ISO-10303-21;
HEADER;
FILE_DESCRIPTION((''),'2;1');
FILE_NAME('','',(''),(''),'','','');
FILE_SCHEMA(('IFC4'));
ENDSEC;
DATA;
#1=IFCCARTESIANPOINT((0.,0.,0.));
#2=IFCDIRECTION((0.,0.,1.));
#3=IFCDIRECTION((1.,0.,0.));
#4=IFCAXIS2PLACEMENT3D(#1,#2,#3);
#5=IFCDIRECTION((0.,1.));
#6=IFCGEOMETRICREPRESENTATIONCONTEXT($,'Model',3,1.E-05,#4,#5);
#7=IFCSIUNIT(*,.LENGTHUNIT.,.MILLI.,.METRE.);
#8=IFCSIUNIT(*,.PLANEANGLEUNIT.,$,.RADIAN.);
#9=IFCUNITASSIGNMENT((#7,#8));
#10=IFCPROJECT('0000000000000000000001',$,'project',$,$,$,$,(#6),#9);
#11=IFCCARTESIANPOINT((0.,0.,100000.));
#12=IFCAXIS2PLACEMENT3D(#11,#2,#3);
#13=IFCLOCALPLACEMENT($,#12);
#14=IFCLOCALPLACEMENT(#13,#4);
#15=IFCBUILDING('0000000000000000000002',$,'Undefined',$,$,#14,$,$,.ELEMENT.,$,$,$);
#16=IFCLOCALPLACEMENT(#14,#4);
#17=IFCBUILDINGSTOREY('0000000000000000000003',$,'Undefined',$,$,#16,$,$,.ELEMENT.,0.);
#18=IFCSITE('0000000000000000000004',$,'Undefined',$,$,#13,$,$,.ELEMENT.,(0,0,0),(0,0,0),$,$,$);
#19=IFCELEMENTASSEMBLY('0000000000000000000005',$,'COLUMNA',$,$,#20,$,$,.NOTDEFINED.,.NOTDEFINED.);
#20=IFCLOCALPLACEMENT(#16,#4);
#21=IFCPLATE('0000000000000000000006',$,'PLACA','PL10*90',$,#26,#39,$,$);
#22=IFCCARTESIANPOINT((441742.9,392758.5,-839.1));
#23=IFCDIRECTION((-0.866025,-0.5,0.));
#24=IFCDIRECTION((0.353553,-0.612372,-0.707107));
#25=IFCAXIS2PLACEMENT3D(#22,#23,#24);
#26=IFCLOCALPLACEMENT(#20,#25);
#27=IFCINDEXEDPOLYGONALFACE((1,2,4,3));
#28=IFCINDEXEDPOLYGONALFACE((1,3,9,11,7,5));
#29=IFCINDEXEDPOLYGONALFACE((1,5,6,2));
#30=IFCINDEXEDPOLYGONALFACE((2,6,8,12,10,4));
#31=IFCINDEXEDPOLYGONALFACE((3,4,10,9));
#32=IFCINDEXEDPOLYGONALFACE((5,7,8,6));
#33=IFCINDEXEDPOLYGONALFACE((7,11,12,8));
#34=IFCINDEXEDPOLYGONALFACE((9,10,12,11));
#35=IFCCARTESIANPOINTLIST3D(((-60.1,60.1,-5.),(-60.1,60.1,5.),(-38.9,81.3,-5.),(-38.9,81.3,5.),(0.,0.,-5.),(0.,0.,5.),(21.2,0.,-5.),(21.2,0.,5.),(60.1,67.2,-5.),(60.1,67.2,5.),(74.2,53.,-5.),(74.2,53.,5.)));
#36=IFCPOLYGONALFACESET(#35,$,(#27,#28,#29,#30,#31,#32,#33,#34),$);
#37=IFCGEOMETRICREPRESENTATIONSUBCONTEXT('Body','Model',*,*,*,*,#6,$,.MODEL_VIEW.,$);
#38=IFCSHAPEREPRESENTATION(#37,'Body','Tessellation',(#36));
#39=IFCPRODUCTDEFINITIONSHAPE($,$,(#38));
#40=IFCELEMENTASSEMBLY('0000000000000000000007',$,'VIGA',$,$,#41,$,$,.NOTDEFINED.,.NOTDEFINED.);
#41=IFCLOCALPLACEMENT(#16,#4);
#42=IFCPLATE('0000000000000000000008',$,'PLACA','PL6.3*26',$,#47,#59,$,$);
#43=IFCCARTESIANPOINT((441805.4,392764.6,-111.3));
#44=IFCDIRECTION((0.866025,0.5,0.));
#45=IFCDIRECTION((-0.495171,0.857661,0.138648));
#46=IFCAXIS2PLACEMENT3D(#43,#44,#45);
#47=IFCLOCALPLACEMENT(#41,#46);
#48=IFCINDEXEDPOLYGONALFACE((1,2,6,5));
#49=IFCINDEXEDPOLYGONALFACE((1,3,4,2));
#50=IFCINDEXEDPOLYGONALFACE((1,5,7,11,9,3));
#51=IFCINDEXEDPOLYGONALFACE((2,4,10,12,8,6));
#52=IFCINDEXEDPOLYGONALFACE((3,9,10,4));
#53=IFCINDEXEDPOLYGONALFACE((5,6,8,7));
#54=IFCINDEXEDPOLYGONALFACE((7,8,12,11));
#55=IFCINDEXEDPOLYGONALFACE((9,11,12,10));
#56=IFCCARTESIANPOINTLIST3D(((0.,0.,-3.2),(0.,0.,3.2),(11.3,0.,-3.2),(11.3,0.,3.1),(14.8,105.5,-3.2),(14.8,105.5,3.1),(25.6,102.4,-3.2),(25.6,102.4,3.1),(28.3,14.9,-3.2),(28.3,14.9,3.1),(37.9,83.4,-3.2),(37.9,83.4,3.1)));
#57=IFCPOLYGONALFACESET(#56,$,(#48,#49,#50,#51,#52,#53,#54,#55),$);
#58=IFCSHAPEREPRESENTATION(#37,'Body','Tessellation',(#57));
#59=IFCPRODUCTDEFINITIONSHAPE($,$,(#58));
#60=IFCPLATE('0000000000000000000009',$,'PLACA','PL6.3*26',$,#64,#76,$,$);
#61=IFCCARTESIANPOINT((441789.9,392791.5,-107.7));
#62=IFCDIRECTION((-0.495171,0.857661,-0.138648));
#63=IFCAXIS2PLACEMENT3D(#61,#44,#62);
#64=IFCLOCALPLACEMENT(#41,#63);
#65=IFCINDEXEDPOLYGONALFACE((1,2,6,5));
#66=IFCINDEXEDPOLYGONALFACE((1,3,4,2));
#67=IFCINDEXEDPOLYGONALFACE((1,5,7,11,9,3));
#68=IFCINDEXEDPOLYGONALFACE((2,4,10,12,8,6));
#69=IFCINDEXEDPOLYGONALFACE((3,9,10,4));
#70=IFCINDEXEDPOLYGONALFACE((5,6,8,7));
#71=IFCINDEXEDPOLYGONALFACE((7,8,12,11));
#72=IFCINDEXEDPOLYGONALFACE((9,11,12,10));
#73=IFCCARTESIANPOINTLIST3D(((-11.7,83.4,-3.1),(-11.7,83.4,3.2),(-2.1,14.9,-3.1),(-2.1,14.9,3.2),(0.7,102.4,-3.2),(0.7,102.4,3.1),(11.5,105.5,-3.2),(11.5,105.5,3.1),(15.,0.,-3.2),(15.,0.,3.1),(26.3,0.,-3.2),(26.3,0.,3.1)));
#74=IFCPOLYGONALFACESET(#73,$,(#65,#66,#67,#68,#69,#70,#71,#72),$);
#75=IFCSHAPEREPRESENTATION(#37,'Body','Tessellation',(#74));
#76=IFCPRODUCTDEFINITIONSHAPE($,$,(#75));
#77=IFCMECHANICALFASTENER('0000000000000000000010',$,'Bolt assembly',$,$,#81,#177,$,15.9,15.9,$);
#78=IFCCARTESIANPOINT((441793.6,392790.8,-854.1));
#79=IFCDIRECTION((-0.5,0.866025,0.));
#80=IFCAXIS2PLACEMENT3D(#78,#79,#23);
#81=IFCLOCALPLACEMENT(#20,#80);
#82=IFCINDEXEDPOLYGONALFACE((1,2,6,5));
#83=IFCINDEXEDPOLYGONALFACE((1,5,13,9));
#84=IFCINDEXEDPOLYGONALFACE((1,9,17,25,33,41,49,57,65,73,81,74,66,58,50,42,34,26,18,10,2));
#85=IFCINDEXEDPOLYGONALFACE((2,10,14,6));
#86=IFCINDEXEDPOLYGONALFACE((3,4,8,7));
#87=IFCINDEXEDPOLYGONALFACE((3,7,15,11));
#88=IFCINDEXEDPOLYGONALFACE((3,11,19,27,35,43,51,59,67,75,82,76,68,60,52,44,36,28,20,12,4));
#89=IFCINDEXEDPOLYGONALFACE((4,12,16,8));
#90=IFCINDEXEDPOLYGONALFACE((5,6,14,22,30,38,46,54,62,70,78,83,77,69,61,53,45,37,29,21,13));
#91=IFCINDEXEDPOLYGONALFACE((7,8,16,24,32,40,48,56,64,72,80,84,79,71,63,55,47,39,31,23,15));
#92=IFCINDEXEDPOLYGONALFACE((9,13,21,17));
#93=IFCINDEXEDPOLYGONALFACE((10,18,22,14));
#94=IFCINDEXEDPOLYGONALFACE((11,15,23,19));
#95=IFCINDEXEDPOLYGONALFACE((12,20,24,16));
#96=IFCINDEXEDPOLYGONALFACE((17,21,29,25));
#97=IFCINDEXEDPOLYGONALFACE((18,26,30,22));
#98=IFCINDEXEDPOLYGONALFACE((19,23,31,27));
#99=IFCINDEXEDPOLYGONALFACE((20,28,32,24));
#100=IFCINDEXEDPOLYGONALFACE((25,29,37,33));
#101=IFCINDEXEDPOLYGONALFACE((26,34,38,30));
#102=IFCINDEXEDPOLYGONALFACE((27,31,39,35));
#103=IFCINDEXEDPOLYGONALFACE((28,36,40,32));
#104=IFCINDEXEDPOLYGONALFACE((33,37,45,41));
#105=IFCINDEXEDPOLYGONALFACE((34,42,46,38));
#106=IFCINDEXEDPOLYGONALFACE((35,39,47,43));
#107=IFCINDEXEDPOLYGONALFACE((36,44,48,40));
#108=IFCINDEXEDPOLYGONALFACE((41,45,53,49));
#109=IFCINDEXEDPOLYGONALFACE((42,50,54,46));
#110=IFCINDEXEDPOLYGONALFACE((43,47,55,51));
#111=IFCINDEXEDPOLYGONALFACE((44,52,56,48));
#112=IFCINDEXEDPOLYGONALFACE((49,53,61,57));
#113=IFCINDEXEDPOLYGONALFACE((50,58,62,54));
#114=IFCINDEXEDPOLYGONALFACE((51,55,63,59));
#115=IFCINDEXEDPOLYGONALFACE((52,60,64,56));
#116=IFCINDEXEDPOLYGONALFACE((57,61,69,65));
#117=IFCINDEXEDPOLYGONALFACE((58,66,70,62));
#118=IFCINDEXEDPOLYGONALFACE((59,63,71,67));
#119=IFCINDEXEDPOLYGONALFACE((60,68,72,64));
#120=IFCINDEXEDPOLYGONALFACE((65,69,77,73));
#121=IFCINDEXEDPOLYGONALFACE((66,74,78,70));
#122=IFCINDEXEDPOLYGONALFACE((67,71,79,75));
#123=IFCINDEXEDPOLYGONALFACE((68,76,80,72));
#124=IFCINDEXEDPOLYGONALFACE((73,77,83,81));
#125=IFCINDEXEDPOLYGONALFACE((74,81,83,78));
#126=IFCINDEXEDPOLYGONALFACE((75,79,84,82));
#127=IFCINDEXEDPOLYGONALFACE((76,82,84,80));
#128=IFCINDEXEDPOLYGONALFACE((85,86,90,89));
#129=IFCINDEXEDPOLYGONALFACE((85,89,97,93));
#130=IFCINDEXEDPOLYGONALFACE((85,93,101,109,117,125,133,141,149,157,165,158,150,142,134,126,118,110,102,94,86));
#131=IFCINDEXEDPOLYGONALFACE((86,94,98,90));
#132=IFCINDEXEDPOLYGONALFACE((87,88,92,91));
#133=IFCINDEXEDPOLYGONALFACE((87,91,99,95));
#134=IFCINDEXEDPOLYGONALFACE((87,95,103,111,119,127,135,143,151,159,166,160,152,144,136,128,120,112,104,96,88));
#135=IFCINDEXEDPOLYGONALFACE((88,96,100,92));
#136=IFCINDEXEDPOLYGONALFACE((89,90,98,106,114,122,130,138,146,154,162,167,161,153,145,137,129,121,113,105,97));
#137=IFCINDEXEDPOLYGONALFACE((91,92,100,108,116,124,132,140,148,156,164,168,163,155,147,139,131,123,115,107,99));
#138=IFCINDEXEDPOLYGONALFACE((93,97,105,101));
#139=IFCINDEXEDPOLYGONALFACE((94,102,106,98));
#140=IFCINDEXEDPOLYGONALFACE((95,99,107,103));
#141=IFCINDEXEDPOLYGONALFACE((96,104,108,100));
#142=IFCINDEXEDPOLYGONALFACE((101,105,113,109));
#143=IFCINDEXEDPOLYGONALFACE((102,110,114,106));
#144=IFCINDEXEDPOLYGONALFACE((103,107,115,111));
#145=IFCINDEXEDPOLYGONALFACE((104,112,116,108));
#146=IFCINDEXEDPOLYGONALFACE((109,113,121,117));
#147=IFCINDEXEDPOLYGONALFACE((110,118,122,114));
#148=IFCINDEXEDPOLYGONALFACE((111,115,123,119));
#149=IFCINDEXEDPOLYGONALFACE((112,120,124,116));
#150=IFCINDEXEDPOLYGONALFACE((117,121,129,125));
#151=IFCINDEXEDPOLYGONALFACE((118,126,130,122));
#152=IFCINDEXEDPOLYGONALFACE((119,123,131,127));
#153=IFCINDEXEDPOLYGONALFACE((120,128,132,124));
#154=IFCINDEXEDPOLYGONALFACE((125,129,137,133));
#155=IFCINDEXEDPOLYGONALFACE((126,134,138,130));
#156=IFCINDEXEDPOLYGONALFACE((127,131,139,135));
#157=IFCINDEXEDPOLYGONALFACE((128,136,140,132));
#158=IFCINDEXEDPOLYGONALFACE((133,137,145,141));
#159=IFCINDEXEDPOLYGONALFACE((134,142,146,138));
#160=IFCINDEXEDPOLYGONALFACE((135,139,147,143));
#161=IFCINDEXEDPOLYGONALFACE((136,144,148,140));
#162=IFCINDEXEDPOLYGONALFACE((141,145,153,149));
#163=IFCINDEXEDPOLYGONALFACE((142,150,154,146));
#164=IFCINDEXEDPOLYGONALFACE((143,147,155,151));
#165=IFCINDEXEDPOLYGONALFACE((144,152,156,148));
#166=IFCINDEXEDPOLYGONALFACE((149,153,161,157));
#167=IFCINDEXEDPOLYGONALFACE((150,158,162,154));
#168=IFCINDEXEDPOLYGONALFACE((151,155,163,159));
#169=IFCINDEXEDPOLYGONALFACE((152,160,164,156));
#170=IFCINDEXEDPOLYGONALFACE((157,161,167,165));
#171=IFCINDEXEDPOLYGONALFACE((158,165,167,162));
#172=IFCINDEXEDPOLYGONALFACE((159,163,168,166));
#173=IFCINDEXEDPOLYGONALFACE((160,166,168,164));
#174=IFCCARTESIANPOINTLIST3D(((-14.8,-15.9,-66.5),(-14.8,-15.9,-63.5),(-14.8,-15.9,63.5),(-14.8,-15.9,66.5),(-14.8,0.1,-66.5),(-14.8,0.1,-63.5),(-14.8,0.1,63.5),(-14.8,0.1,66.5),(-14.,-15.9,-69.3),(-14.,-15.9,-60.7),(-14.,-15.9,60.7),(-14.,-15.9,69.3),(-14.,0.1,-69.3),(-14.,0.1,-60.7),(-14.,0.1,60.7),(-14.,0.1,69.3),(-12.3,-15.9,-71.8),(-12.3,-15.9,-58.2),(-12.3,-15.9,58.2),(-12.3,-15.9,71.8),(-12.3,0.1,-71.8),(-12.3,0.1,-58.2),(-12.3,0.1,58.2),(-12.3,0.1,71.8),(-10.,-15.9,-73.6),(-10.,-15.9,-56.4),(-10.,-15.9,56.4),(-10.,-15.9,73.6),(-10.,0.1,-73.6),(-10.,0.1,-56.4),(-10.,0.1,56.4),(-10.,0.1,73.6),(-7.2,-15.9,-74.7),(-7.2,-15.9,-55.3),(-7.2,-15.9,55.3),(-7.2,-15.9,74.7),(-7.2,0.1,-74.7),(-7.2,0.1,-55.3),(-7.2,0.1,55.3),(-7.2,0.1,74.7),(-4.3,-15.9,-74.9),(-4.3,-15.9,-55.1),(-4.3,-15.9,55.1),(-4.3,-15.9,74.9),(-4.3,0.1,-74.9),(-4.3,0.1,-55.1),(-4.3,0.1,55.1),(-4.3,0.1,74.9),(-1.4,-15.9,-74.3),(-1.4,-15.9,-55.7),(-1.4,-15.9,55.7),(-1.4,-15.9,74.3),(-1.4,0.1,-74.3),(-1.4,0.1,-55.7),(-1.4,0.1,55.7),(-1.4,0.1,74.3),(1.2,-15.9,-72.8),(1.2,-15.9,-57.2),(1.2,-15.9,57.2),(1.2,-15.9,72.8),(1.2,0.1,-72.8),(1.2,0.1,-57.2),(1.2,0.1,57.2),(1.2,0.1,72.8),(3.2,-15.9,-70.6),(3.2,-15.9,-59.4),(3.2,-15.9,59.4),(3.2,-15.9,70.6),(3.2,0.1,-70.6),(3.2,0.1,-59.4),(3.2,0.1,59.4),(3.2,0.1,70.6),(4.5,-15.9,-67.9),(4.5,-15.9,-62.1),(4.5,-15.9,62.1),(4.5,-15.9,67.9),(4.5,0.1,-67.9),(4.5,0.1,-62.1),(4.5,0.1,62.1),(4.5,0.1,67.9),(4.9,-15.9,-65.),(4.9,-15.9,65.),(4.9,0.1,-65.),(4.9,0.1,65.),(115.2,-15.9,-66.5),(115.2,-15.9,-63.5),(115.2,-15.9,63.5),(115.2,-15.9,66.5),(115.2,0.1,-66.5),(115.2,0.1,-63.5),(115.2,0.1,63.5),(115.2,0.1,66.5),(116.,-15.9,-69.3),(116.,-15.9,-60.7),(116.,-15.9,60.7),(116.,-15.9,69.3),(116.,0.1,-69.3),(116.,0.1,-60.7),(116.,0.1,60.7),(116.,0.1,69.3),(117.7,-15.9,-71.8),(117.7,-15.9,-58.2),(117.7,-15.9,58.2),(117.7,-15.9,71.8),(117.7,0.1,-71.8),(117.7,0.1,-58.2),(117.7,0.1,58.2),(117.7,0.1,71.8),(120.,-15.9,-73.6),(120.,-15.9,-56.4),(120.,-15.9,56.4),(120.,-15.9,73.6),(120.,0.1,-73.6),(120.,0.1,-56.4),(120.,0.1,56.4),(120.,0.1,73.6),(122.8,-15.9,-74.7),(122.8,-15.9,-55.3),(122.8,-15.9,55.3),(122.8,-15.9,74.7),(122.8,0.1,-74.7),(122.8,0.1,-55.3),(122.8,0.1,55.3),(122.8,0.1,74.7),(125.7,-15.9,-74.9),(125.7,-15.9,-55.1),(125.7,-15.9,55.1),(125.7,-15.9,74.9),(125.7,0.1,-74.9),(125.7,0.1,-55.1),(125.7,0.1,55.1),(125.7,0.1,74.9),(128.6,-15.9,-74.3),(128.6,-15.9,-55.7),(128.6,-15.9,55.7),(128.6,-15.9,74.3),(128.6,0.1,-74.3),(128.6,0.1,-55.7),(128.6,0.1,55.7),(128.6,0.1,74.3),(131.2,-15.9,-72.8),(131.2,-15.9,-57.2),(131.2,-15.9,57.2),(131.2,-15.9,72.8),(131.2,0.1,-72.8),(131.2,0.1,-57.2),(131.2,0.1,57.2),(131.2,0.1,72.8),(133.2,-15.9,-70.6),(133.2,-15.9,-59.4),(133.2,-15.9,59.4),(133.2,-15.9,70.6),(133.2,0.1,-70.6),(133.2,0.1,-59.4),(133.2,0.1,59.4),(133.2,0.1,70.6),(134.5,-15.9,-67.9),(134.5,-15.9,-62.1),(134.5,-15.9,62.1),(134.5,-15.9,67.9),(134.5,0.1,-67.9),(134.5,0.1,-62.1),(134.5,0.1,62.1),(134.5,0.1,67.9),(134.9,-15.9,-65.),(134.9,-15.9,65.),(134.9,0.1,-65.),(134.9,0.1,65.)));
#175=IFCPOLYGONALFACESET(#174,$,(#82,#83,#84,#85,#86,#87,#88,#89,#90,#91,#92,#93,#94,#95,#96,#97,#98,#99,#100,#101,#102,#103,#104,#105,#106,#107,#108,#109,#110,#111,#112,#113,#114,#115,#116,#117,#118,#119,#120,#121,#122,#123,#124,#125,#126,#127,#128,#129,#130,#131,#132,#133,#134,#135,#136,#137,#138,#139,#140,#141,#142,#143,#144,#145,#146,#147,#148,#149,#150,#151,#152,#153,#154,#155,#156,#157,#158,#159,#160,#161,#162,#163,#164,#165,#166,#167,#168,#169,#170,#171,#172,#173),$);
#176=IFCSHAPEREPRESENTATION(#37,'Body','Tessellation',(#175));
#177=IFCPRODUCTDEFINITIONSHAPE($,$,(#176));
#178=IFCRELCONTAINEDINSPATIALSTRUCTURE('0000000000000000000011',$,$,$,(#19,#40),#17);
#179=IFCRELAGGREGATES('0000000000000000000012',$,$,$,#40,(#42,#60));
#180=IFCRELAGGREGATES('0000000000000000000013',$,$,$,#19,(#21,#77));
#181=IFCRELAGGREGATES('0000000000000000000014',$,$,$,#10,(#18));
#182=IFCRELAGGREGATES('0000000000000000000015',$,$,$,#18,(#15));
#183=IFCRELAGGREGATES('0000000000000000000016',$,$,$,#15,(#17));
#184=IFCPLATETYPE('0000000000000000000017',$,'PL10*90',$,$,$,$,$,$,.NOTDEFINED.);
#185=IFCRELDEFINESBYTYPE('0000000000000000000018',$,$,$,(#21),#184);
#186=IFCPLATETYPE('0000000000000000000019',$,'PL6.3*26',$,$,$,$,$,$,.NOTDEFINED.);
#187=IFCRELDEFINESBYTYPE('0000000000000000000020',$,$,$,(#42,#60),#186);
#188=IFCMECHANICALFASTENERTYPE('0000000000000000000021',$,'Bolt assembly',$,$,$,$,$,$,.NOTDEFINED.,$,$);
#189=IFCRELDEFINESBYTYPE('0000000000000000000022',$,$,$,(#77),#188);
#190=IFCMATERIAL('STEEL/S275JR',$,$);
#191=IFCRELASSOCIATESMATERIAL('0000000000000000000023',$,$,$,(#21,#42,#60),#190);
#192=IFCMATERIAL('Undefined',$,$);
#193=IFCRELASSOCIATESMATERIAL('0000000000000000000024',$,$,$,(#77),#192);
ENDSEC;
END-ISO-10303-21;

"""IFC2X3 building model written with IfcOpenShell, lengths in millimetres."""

from ifc_helpers import new_model, si_unit, direction, frame, origin_with_axes, origin_2d_with_axis, place, context, subcontext, project, spatial, polyline, circle, outline, extrude, source, transform, mapped, material, type_object, element, aggregate, save


model = new_model("IFC2X3")

# Units and contexts
model_context = context("Model", 3, precision=1e-05, world=origin_with_axes(), true_north=direction((0.0, 1.0)))
body_context = subcontext(model_context, "Body", "Model", "MODEL_VIEW")
ifc_project = project(units=[si_unit("LENGTHUNIT", "METRE", prefix="MILLI"), si_unit("PLANEANGLEUNIT", "RADIAN")], contexts=[model_context])

# Site, building, storey
site_placement = place(None, frame((0.0, 0.0, 100000.0), z_axis=(0.0, 0.0, 1.0), x_axis=(1.0, 0.0, 0.0)))
site = spatial("IfcSite", under=ifc_project, at=site_placement, Name="Undefined", CompositionType="ELEMENT", RefLatitude=(0, 0, 0), RefLongitude=(0, 0, 0))
building_placement = place(site_placement, origin_with_axes())
building = spatial("IfcBuilding", under=site, at=building_placement, Name="Undefined", CompositionType="ELEMENT")
storey_placement = place(building_placement, origin_with_axes())
storey = spatial("IfcBuildingStorey", under=building, at=storey_placement, Name="Undefined", CompositionType="ELEMENT", Elevation=0.0)

# Shared definitions
ifc_material_1 = material(Name="STEEL/S275JR")

# Element assembly, plate
assembly_1_placement = place(storey_placement, origin_with_axes())
assembly_1 = element("IfcElementAssembly", 1, at=assembly_1_placement, inside=storey, Name="COLUMNA", AssemblyPlace="NOTDEFINED", PredefinedType="NOTDEFINED")
plate_type_1 = type_object("IfcPlateType", Name="PL10*90", PredefinedType="NOTDEFINED")
plate_1_placement = place(assembly_1_placement, frame((441742.9, 392758.5, -839.1), z_axis=(-0.866025, -0.5, 0.0), x_axis=(0.353553, -0.612372, -0.707107)))
plate_1 = element("IfcPlate", 2, at=plate_1_placement, type_object=plate_type_1, material=ifc_material_1, Name="PLACA", Description="PL10*90", context=body_context, shape_type="SweptSolid", body=[
    extrude(outline(polyline([(0.0, 0.0), (21.2, 0.0), (74.2, 53.0), (60.1, 67.2), (-38.9, 81.3), (-60.1, 60.1), (0.0, 0.0)])), frame((0.0, 0.0, -5.0), z_axis=(0.0, 0.0, 1.0), x_axis=(1.0, 0.0, 0.0)), (0.0, 0.0, 1.0), 10.0),
])

# Element assembly, plates
assembly_2_placement = place(storey_placement, origin_with_axes())
assembly_2 = element("IfcElementAssembly", 3, at=assembly_2_placement, inside=storey, Name="VIGA", AssemblyPlace="NOTDEFINED", PredefinedType="NOTDEFINED")
plate_type_2 = type_object("IfcPlateType", Name="PL6.3*26", PredefinedType="NOTDEFINED")
plate_2_placement = place(assembly_2_placement, frame((441805.4, 392764.6, -111.3), z_axis=(0.866025, 0.5, 0.0), x_axis=(-0.495171, 0.857661, 0.138648)))
plate_2 = element("IfcPlate", 4, at=plate_2_placement, type_object=plate_type_2, material=ifc_material_1, Name="PLACA", Description="PL6.3*26", context=body_context, shape_type="SweptSolid", body=[
    extrude(outline(polyline([(0.0, 0.0), (11.3, 0.0), (28.3, 14.9), (37.9, 83.4), (25.6, 102.4), (14.8, 105.5), (0.0, 0.0)])), frame((0.0, 0.0, -3.1), z_axis=(0.0, 0.0, 1.0), x_axis=(1.0, 0.0, 0.0)), (0.0, 0.0, 1.0), 6.3),
])
plate_3_placement = place(assembly_2_placement, frame((441789.9, 392791.5, -107.7), z_axis=(0.866025, 0.5, 0.0), x_axis=(-0.495171, 0.857661, -0.138648)))
plate_3 = element("IfcPlate", 5, at=plate_3_placement, type_object=plate_type_2, material=ifc_material_1, Name="PLACA", Description="PL6.3*26", context=body_context, shape_type="SweptSolid", body=[
    extrude(outline(polyline([(-2.1, 14.9), (15.0, 0.0), (26.3, 0.0), (11.5, 105.5), (0.7, 102.4), (-11.7, 83.4), (-2.1, 14.9)])), frame((0.0, 0.0, -3.1), z_axis=(0.0, 0.0, 1.0), x_axis=(1.0, 0.0, 0.0)), (0.0, 0.0, 1.0), 6.3),
])
aggregate(assembly_2, [plate_2, plate_3])

# Mechanical fastener
ifc_material_2 = material(Name="Undefined")
mechanical_fastener_type = type_object("IfcMechanicalFastenerType", Name="Bolt assembly")
shared_shape_1 = source(origin_with_axes(), body_context, "Body", "SweptSolid", [
    extrude(circle(Radius=9.9, at=origin_2d_with_axis()), frame((0.0, -15.9, 0.0), z_axis=(0.0, 1.0, 0.0), x_axis=(1.0, 0.0, 0.0)), (0.0, 0.0, 1.0), 16.0),
])
mechanical_fastener_placement = place(assembly_1_placement, frame((441793.6, 392790.8, -854.1), z_axis=(-0.5, 0.866025, 0.0), x_axis=(-0.866025, -0.5, 0.0)))
mechanical_fastener = element("IfcMechanicalFastener", 6, at=mechanical_fastener_placement, type_object=mechanical_fastener_type, material=ifc_material_2, Name="Bolt assembly", NominalDiameter=15.9, NominalLength=15.9, context=body_context, shape_type="MappedRepresentation", body=[
    mapped(shared_shape_1, transform((-5.0, 0.0, -65.0))),
    mapped(shared_shape_1, transform((-5.0, 0.0, 65.0))),
    mapped(shared_shape_1, transform((125.0, 0.0, -65.0))),
    mapped(shared_shape_1, transform((125.0, 0.0, 65.0))),
])
aggregate(assembly_1, [plate_1, mechanical_fastener])

save(model, "model.ifc")
